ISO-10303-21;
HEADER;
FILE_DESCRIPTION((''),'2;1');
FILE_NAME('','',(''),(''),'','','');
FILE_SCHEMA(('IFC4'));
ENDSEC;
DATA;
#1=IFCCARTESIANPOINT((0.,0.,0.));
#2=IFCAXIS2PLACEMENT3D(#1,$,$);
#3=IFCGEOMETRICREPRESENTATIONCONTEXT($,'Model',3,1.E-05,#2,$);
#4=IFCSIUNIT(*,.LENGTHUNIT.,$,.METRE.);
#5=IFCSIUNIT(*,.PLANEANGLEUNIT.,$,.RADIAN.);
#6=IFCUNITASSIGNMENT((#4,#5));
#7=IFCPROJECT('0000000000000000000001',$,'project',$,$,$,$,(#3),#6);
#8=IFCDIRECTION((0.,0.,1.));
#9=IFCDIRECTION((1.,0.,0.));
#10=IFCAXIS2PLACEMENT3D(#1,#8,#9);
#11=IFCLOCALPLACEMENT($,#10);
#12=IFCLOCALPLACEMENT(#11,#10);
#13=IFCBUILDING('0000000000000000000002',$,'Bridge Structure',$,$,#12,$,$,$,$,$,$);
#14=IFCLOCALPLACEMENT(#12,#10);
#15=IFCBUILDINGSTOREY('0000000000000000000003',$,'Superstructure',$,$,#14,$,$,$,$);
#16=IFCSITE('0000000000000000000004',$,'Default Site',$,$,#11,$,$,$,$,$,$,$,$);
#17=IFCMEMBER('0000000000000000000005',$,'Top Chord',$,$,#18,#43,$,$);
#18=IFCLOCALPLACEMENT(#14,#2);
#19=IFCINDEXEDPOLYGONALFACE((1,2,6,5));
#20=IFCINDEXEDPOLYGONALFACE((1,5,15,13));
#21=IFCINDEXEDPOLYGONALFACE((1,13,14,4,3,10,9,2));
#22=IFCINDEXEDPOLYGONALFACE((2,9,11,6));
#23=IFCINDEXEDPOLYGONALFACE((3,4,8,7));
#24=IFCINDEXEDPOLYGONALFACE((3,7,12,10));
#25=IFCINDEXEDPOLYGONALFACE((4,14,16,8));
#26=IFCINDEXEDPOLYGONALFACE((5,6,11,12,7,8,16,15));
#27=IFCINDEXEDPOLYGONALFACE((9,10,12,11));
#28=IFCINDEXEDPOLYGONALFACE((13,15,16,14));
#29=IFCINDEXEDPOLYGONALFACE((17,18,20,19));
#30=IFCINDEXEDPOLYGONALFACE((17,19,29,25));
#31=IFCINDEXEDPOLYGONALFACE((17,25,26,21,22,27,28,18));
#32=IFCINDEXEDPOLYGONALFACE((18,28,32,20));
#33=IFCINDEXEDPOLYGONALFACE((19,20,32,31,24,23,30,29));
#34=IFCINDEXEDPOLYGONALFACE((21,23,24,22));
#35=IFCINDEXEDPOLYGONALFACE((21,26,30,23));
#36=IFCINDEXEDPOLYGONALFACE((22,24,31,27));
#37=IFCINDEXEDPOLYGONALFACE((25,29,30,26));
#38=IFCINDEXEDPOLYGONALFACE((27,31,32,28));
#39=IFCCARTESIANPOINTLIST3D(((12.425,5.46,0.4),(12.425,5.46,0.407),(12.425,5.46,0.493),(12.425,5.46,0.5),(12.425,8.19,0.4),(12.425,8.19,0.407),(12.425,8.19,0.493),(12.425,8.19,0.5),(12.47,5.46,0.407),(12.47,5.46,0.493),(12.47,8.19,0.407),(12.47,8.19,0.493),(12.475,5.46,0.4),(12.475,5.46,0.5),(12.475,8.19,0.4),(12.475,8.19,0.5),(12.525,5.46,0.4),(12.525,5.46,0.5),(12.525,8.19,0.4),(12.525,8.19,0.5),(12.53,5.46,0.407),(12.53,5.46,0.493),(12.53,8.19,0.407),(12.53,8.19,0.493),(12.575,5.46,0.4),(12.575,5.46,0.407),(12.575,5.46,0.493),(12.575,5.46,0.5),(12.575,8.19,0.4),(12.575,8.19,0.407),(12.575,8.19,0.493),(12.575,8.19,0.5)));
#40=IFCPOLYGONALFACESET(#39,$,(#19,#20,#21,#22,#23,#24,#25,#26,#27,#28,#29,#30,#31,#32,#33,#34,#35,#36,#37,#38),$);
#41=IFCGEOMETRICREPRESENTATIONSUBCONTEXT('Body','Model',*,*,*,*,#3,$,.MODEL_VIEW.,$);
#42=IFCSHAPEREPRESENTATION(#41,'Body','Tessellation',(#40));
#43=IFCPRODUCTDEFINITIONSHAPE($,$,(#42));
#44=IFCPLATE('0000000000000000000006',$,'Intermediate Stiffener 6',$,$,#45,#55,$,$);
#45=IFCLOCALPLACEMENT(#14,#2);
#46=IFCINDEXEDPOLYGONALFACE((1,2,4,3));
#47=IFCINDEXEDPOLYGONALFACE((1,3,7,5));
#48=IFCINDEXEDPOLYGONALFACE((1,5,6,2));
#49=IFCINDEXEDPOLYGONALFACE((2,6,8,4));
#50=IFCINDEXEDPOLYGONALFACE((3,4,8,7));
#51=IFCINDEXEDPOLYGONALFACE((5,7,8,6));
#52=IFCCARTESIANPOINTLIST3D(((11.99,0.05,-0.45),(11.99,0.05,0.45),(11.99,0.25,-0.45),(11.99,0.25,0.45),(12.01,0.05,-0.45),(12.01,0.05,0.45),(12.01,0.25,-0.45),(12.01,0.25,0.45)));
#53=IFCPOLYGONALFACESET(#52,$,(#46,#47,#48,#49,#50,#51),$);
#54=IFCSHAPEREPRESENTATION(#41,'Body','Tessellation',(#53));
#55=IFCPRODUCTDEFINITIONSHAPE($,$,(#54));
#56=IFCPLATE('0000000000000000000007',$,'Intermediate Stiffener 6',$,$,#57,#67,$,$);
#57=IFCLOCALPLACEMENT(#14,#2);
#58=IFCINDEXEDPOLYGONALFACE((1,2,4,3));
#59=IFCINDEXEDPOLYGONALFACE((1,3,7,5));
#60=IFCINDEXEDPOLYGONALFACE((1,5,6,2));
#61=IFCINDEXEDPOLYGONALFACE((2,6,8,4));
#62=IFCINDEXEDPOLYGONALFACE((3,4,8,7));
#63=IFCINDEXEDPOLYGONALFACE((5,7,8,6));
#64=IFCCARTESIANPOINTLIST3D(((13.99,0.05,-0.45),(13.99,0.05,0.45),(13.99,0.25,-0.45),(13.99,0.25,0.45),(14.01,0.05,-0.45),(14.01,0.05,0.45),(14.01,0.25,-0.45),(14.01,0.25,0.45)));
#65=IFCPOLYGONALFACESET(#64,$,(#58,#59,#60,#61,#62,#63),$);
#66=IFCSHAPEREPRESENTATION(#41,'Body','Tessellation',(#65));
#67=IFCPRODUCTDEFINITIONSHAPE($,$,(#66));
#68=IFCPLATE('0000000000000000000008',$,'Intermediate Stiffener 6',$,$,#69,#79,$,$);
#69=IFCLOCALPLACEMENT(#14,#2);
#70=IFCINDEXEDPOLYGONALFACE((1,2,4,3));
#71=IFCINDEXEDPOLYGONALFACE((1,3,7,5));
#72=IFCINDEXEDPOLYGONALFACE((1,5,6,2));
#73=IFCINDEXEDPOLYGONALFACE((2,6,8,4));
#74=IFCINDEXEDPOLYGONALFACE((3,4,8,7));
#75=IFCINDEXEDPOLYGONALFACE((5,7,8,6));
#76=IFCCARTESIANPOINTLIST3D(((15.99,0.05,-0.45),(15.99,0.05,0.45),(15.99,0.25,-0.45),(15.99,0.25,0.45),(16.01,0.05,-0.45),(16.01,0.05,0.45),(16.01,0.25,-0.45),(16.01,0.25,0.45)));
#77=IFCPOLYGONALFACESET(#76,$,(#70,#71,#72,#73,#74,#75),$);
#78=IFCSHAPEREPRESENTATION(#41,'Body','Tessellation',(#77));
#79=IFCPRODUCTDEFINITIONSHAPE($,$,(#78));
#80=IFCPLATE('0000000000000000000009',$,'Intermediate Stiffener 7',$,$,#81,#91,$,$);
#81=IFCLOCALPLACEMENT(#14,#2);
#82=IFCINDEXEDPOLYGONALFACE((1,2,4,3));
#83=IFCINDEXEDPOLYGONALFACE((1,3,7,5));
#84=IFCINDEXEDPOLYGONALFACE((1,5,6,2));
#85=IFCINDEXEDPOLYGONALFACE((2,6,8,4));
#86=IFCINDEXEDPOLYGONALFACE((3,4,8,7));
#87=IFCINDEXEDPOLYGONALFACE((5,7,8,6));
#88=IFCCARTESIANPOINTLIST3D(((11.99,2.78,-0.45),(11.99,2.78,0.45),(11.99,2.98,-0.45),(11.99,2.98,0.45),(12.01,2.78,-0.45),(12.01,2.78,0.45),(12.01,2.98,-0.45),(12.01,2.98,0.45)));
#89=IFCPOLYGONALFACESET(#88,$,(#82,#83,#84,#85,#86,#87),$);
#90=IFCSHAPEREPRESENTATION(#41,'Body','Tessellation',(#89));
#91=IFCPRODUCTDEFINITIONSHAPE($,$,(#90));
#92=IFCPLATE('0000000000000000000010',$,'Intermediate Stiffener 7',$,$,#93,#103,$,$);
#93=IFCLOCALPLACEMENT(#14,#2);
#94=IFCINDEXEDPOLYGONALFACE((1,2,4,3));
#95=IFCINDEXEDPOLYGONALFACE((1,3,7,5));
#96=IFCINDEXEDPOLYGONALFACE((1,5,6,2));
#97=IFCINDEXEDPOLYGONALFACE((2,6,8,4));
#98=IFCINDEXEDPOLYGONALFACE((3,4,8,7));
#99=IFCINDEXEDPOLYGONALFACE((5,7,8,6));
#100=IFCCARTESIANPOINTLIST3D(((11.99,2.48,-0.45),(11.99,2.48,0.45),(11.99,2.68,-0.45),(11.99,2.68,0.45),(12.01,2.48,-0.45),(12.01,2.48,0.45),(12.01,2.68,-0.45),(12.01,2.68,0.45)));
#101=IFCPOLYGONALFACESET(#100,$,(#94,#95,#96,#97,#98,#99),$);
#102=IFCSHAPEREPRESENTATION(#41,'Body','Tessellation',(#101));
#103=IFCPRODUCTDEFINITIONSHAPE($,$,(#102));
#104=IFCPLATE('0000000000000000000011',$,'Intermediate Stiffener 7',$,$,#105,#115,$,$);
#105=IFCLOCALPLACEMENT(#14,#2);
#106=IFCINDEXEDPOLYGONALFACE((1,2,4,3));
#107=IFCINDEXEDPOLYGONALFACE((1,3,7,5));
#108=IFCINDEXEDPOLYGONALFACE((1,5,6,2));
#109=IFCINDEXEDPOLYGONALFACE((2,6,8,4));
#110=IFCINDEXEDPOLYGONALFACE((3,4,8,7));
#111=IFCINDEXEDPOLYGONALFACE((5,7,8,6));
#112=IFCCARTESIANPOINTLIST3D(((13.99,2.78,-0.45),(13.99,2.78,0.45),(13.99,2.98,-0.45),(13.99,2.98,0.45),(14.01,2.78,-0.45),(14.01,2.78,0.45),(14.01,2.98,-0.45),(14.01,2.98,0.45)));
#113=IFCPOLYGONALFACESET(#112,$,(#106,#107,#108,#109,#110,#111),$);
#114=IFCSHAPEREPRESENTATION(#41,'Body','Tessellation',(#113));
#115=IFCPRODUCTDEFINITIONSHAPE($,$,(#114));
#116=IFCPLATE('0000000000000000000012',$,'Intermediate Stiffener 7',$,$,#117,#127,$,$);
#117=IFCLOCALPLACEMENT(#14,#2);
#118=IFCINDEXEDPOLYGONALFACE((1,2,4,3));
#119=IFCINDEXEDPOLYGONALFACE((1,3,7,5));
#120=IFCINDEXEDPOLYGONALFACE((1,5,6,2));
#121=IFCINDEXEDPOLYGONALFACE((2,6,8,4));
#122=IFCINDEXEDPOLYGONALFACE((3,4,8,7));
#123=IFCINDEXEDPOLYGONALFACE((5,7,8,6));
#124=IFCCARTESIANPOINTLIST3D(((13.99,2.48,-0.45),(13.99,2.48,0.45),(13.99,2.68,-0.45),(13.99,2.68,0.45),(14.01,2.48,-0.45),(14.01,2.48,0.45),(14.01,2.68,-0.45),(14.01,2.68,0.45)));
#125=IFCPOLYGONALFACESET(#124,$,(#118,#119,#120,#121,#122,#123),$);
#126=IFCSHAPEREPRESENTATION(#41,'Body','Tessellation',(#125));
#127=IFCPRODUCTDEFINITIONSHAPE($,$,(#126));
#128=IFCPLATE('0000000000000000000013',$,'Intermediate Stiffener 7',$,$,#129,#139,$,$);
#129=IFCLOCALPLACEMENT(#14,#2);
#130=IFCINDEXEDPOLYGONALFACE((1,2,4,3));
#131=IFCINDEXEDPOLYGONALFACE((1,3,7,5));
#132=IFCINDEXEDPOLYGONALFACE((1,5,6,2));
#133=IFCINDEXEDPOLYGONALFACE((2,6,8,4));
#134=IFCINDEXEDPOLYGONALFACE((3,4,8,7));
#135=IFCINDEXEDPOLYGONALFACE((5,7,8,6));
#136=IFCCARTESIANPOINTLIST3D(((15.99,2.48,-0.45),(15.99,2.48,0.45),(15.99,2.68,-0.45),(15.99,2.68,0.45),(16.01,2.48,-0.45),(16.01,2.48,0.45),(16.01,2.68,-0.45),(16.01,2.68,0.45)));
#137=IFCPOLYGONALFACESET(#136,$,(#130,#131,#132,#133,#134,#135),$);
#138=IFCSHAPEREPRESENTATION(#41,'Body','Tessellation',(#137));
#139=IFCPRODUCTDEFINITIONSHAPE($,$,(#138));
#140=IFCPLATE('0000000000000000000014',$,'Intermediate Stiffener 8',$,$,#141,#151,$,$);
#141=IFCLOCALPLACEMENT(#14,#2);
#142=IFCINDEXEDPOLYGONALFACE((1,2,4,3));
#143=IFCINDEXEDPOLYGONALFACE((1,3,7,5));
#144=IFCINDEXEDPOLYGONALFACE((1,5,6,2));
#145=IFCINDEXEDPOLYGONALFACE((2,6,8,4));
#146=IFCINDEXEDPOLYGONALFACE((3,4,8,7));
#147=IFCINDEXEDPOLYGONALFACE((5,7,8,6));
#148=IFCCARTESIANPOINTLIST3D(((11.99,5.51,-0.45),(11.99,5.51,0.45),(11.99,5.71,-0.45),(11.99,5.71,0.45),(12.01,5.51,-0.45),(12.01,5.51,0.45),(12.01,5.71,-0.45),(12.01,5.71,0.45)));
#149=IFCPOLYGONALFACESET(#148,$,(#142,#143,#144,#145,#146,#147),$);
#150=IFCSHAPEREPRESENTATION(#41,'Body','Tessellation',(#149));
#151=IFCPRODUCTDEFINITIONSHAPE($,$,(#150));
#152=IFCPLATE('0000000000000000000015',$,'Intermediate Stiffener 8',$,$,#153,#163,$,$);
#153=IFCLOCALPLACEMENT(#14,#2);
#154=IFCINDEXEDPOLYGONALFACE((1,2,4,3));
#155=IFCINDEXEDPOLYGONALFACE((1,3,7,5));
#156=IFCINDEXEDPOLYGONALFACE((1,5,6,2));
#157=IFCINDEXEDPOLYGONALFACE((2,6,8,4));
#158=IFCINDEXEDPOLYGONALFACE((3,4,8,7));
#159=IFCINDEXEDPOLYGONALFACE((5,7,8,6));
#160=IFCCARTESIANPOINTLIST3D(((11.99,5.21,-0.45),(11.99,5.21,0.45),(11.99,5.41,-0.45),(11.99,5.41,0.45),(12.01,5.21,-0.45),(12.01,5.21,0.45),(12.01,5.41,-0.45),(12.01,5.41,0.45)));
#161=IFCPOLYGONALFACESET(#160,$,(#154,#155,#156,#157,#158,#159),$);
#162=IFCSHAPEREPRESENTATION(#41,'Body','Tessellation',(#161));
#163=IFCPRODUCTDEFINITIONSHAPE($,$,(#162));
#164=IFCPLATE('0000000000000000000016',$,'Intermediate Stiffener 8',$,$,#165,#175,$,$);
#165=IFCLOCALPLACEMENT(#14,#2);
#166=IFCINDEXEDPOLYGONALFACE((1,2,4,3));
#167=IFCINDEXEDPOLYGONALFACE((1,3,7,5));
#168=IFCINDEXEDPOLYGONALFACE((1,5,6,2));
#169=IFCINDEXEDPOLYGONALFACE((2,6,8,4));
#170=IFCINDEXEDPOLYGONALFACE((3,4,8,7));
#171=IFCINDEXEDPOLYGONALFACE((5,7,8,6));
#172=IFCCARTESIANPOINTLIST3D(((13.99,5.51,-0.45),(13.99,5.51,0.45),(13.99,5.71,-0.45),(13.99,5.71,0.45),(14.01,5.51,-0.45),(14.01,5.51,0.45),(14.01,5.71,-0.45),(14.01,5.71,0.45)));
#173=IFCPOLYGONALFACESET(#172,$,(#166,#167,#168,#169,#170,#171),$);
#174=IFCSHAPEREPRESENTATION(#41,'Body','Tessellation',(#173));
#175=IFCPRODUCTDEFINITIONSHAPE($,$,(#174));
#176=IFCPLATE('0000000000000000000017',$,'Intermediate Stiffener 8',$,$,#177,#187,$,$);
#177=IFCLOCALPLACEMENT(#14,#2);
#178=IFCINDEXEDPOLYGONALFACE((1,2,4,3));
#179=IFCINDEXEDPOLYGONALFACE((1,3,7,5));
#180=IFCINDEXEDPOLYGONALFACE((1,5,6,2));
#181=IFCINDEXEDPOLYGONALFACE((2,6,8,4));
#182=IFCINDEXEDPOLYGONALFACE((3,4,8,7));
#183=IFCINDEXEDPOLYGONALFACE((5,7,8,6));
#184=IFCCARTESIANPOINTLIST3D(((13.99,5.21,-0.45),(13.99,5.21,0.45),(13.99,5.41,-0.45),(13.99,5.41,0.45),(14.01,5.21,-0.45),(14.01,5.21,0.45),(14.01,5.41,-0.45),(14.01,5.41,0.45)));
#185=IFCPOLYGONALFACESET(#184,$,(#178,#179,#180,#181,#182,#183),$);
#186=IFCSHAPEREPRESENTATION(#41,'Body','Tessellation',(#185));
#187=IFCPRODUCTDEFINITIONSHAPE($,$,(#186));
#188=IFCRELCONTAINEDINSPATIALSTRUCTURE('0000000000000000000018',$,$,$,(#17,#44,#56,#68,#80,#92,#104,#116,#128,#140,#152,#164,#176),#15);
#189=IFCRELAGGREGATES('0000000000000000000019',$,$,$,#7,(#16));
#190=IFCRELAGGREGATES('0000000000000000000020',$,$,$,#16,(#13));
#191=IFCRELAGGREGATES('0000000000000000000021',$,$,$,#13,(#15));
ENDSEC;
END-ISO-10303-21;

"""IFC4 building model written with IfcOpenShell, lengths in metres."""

from ifc_helpers import new_model, si_unit, frame, origin, origin_with_axes, origin_2d_with_axis, place, context, subcontext, project, spatial, polyline, rectangle, outline, composite_profile, extrude, element, save


model = new_model("IFC4")

# Units and contexts
model_context = context("Model", 3, precision=1e-05, world=origin())
body_context = subcontext(model_context, "Body", "Model", "MODEL_VIEW")
ifc_project = project(units=[si_unit("LENGTHUNIT", "METRE"), si_unit("PLANEANGLEUNIT", "RADIAN")], contexts=[model_context])

# Site, building, storey
site_placement = place(None, origin_with_axes())
site = spatial("IfcSite", under=ifc_project, at=site_placement, Name="Default Site")
building_placement = place(site_placement, origin_with_axes())
building = spatial("IfcBuilding", under=site, at=building_placement, Name="Bridge Structure")
storey_placement = place(building_placement, origin_with_axes())
storey = spatial("IfcBuildingStorey", under=building, at=storey_placement, Name="Superstructure")

# Member
member_1_placement = place(storey_placement, frame((12.5, 5.46, 0.45), z_axis=(0.0, 1.0, 0.0), x_axis=(-1.0, 0.0, 0.0)))
element("IfcMember", 1, at=member_1_placement, inside=storey, Name="Top Chord", context=body_context, shape_type="SweptSolid", body=[
    extrude(composite_profile([outline(polyline([(-0.025, -0.05), (-0.025, 0.05), (-0.075, 0.05), (-0.075, 0.043), (-0.03, 0.043), (-0.03, -0.043), (-0.075, -0.043), (-0.075, -0.05), (-0.025, -0.05)])), outline(polyline([(0.025, -0.05), (0.075, -0.05), (0.075, -0.043), (0.03, -0.043), (0.03, 0.043), (0.075, 0.043), (0.075, 0.05), (0.025, 0.05), (0.025, -0.05)]))]), origin_with_axes(), (0.0, 0.0, 1.0), 2.73),
])

# Plates
for number, where, z_axis, x_axis, name in (
    (2, (12.0, 0.15, -0.45), (0.0, 0.0, 1.0), (1.0, 0.0, 0.0), "Intermediate Stiffener 6"),
    (3, (14.0, 0.15, -0.45), (0.0, 0.0, 1.0), (1.0, 0.0, 0.0), "Intermediate Stiffener 6"),
    (4, (16.0, 0.15, -0.45), (0.0, 0.0, 1.0), (1.0, 0.0, 0.0), "Intermediate Stiffener 6"),
    (5, (12.0, 2.88, -0.45), (0.0, 0.0, 1.0), (1.0, 0.0, 0.0), "Intermediate Stiffener 7"),
    (6, (12.0, 2.58, -0.45), (0.0, 0.0, 1.0), (1.0, 0.0, 0.0), "Intermediate Stiffener 7"),
    (7, (14.0, 2.88, -0.45), (0.0, 0.0, 1.0), (1.0, 0.0, 0.0), "Intermediate Stiffener 7"),
    (8, (14.0, 2.58, -0.45), (0.0, 0.0, 1.0), (1.0, 0.0, 0.0), "Intermediate Stiffener 7"),
    (9, (16.0, 2.58, -0.45), (0.0, 0.0, 1.0), (1.0, 0.0, 0.0), "Intermediate Stiffener 7"),
    (10, (12.0, 5.61, -0.45), (0.0, 0.0, 1.0), (1.0, 0.0, 0.0), "Intermediate Stiffener 8"),
    (11, (12.0, 5.31, -0.45), (0.0, 0.0, 1.0), (1.0, 0.0, 0.0), "Intermediate Stiffener 8"),
    (12, (14.0, 5.61, -0.45), (0.0, 0.0, 1.0), (1.0, 0.0, 0.0), "Intermediate Stiffener 8"),
    (13, (14.0, 5.31, -0.45), (0.0, 0.0, 1.0), (1.0, 0.0, 0.0), "Intermediate Stiffener 8"),
):
    element("IfcPlate", number, at=place(storey_placement, frame(where, z_axis=z_axis, x_axis=x_axis)), inside=storey, Name=name, context=body_context, shape_type="SweptSolid", body=[
        extrude(rectangle(XDim=0.02, YDim=0.2, at=origin_2d_with_axis()), origin_with_axes(), (0.0, 0.0, 1.0), 0.9),
    ])

save(model, "model.ifc")
